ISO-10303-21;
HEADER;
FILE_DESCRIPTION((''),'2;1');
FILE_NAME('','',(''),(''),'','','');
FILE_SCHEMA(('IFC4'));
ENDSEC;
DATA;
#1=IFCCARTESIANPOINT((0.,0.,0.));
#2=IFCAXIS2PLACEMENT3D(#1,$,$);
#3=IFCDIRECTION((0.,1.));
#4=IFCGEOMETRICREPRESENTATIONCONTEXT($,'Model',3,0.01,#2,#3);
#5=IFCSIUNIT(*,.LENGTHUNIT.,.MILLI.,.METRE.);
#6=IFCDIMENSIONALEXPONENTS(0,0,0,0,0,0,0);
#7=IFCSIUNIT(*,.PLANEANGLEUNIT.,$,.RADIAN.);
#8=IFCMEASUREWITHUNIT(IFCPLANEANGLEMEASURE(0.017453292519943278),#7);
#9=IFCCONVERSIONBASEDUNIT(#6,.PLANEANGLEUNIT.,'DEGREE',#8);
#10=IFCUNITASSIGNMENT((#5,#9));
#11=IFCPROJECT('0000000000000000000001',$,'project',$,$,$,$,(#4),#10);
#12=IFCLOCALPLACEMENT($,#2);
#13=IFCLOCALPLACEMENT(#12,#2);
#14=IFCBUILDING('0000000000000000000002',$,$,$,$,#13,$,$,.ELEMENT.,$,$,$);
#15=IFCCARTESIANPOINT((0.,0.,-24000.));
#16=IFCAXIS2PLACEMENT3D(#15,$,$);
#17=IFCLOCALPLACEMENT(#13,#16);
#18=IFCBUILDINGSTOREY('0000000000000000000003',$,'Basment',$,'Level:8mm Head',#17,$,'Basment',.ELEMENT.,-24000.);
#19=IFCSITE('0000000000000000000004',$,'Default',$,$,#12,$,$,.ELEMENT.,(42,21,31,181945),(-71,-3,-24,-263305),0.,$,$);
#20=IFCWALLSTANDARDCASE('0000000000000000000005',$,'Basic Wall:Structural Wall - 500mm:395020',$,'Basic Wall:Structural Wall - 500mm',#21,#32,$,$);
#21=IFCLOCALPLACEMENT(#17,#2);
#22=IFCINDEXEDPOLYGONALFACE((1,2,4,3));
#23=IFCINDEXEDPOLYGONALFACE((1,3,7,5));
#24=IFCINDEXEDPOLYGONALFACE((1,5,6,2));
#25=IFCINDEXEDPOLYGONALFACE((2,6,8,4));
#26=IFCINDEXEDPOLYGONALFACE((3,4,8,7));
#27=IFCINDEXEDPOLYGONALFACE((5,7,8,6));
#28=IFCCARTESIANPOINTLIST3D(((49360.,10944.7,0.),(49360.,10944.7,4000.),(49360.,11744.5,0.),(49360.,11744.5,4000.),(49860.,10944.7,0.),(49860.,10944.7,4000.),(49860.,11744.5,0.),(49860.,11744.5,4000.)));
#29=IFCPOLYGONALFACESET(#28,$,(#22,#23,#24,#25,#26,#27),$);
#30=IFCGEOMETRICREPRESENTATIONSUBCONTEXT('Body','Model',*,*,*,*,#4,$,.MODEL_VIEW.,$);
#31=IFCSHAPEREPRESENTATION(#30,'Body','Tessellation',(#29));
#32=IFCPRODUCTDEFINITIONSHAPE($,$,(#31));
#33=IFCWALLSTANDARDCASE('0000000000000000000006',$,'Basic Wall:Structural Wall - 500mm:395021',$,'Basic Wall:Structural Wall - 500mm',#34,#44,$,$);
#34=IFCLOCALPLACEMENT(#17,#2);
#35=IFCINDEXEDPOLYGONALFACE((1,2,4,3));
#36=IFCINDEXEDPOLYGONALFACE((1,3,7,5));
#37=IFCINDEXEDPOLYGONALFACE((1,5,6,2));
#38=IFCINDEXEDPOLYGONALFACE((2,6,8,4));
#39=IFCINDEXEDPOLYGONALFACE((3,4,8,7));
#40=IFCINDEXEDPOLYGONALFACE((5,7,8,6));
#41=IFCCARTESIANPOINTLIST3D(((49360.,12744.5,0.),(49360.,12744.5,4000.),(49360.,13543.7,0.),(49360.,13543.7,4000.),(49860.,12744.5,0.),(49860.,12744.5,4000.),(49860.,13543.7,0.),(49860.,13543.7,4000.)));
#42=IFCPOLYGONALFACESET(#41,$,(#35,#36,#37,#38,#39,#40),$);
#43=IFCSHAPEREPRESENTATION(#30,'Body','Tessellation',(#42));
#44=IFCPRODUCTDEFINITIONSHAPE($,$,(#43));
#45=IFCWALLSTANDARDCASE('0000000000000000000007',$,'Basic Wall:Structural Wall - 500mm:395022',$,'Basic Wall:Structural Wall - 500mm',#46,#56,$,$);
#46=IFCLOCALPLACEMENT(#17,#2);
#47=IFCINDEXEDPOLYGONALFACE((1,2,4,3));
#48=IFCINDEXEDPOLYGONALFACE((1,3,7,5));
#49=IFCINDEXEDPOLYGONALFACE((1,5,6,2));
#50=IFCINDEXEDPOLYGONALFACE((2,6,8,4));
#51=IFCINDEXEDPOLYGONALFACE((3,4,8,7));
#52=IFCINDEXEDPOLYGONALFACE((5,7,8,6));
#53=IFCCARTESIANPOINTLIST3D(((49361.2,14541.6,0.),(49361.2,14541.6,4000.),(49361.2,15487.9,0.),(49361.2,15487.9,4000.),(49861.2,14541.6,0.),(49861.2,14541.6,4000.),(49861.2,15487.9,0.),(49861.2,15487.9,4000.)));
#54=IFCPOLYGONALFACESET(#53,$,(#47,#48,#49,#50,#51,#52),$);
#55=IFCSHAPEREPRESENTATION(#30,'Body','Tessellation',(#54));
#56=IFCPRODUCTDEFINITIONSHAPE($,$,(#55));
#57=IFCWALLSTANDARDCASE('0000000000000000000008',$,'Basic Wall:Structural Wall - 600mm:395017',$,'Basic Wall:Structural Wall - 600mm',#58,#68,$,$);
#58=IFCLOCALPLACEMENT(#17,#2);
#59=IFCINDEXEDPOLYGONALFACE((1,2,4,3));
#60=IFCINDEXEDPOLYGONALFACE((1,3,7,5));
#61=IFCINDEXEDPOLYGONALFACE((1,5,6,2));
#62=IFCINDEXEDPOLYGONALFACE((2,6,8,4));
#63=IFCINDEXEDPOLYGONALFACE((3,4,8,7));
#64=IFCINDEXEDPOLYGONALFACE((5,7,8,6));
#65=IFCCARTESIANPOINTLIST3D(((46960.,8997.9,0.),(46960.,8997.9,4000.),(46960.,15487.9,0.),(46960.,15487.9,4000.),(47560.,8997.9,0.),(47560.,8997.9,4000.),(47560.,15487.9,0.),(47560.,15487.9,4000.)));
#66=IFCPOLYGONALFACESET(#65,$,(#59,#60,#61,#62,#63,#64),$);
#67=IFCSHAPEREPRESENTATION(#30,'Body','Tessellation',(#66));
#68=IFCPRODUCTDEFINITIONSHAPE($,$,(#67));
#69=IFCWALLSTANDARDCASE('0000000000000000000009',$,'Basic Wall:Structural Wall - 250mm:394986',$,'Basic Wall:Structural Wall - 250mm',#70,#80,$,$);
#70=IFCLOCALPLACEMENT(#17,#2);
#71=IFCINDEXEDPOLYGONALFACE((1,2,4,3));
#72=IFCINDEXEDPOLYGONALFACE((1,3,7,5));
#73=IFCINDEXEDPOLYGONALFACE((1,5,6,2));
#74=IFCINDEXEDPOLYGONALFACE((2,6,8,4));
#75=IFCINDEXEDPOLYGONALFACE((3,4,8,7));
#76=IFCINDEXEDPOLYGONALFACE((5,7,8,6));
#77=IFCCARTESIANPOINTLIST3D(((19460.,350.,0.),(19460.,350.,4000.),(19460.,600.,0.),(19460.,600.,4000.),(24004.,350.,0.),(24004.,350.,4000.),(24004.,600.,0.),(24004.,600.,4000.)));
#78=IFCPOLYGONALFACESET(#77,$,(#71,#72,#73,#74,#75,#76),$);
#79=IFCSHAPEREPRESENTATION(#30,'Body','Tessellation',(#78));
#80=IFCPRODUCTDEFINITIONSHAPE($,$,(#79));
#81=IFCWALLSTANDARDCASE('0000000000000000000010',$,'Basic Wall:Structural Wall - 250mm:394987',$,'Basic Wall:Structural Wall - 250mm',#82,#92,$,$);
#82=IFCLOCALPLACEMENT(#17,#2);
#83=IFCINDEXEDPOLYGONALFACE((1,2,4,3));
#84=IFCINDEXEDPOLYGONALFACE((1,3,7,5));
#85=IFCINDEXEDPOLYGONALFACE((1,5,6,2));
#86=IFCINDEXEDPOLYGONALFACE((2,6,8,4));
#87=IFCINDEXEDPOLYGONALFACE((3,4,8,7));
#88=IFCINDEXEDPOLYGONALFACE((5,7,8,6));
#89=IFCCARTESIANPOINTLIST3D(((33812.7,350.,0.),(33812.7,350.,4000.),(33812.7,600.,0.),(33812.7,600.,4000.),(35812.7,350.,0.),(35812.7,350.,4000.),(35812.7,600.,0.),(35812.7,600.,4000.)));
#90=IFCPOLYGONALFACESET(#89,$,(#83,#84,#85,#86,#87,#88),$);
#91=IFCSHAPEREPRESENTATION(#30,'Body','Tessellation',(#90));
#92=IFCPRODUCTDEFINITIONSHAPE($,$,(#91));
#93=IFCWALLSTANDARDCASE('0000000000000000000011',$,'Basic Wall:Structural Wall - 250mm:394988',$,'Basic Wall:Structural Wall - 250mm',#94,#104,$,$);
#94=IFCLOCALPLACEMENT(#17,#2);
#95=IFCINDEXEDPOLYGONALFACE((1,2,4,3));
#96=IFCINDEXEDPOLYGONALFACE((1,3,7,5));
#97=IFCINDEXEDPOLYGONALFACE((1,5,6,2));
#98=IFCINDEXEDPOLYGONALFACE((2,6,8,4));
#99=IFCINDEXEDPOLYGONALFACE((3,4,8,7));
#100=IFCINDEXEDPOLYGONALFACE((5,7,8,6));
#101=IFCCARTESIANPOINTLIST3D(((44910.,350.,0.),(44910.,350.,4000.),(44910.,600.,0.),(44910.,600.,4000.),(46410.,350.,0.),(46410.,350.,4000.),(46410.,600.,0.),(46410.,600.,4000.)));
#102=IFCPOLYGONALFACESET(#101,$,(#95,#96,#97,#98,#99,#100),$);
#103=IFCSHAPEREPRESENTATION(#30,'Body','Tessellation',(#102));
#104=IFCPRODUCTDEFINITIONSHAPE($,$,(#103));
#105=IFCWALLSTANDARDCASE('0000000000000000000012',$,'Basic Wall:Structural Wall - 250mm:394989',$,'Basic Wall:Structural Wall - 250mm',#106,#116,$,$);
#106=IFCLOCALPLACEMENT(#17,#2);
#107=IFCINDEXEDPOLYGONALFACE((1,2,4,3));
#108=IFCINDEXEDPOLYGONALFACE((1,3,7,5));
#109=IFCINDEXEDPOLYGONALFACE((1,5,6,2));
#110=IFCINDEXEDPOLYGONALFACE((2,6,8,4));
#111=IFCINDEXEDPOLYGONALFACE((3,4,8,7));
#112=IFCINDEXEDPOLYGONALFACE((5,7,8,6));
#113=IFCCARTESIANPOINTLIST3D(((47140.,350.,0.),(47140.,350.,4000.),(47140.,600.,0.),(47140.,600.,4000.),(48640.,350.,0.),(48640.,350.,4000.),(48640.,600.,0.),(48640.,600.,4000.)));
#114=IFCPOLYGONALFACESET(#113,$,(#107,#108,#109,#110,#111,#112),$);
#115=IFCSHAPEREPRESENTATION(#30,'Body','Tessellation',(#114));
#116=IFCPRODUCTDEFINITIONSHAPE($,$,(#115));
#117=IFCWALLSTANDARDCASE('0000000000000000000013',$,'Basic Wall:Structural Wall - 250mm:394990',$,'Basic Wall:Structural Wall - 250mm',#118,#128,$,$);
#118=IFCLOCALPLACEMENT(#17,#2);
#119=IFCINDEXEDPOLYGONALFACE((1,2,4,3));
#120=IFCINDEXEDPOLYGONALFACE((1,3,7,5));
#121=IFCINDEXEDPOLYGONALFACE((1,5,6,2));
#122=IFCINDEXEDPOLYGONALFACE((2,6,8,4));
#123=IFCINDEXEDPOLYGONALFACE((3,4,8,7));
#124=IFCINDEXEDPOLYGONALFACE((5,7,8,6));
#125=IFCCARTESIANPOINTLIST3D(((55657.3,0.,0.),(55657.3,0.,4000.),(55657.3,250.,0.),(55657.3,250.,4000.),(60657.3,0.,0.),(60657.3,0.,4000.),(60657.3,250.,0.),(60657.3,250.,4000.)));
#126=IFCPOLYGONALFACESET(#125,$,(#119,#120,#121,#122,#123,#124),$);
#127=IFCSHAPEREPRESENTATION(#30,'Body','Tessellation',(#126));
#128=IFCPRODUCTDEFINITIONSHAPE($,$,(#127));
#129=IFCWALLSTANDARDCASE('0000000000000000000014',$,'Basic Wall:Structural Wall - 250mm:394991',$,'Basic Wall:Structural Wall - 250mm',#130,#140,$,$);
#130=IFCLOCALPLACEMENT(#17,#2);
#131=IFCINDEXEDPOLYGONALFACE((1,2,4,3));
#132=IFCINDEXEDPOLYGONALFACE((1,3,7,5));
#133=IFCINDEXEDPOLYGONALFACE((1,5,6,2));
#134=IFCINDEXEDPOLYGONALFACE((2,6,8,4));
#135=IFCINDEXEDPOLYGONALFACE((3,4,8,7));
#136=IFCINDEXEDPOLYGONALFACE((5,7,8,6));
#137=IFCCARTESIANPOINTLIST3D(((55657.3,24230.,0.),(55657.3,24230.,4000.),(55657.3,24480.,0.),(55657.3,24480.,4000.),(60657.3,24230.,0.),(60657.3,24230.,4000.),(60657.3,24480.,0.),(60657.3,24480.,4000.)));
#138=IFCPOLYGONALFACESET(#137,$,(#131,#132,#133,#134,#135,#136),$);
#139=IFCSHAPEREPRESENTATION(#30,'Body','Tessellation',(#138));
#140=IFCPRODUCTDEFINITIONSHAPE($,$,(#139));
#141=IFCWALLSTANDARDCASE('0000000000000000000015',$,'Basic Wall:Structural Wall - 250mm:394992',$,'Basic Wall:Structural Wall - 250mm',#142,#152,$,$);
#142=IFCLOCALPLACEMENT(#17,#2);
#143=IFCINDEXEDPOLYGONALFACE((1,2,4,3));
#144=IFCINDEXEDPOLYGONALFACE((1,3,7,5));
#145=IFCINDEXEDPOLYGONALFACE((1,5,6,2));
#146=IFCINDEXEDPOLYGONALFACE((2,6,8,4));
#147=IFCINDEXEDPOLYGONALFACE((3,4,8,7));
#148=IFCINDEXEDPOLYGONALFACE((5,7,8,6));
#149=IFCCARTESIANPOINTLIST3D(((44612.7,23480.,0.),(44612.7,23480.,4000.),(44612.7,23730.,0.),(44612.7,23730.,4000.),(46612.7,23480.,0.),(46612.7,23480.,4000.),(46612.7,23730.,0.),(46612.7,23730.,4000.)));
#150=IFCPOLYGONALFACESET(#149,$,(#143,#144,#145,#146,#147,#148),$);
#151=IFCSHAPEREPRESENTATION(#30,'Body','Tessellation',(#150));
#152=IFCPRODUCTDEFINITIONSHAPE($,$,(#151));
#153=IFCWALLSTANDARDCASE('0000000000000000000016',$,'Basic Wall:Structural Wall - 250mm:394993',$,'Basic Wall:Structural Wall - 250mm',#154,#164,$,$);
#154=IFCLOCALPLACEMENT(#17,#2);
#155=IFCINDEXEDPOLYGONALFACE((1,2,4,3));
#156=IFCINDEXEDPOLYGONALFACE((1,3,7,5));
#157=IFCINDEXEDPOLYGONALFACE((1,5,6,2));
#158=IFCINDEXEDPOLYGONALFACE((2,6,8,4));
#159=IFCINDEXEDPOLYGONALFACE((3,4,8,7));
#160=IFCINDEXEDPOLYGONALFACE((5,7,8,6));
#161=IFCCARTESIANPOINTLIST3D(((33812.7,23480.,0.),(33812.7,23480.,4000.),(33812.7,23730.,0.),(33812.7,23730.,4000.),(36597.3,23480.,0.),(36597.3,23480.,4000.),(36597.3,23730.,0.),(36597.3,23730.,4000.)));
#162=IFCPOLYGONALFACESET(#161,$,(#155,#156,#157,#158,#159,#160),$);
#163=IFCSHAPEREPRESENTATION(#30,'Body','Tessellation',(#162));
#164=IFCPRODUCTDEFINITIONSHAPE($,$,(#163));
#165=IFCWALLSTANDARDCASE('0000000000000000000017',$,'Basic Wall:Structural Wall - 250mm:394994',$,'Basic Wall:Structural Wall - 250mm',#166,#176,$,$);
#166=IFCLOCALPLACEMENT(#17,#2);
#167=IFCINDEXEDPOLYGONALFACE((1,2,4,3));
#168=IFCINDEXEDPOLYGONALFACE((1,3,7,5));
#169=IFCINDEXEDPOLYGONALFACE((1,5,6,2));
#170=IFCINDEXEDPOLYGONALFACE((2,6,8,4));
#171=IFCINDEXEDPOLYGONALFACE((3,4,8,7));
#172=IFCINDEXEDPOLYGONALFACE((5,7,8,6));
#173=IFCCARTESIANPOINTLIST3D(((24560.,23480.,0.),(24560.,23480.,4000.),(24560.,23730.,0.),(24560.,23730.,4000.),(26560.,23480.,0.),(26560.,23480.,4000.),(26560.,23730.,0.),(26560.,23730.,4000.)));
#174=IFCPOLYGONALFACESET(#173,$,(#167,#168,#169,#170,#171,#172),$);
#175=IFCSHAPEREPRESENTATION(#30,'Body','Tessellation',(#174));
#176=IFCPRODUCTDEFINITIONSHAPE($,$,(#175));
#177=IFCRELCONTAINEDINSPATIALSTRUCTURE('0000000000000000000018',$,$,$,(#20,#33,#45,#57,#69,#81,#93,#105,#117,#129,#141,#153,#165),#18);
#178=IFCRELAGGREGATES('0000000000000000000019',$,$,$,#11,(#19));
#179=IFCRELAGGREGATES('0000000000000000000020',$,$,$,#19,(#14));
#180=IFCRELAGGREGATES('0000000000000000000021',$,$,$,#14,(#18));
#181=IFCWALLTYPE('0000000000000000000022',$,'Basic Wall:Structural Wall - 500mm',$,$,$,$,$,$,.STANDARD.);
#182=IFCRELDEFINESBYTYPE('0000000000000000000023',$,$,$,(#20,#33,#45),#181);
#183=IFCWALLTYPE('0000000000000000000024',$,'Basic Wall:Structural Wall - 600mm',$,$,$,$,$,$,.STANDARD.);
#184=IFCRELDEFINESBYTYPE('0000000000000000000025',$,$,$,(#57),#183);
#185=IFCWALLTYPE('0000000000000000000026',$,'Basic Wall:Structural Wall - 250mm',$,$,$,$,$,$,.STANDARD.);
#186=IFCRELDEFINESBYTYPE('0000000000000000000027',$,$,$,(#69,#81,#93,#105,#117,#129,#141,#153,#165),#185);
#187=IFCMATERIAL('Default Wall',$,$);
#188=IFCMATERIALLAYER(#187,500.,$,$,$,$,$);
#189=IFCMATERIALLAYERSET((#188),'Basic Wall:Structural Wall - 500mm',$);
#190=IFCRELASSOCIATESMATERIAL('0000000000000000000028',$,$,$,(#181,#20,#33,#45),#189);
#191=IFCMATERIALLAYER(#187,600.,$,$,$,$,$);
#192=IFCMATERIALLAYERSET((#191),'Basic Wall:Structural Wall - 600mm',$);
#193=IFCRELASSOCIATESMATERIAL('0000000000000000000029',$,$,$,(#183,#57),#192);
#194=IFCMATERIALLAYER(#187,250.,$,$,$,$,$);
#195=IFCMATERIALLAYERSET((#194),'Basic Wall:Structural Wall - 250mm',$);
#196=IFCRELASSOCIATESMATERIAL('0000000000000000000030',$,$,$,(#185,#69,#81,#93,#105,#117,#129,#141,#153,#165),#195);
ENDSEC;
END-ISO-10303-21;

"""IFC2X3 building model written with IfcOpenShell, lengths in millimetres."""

from ifc_helpers import new_model, entity, si_unit, converted_unit, direction, frame, frame_2d, origin, place, context, subcontext, project, spatial, rectangle, extrude, material, layer, layer_set, layer_usage, type_object, element, save


model = new_model("IFC2X3")

# Units and contexts
model_context = context("Model", 3, precision=0.01, world=origin(), true_north=direction((0.0, 1.0)))
body_context = subcontext(model_context, "Body", "Model", "MODEL_VIEW")
ifc_project = project(units=[si_unit("LENGTHUNIT", "METRE", prefix="MILLI"), converted_unit("PLANEANGLEUNIT", "DEGREE", entity("IfcPlaneAngleMeasure", 0.017453292519943278), si_unit("PLANEANGLEUNIT", "RADIAN"), dimensions=[0, 0, 0, 0, 0, 0, 0])], contexts=[model_context])

# Site, building, storey
site_placement = place(None, origin())
site = spatial("IfcSite", under=ifc_project, at=site_placement, Name="Default", CompositionType="ELEMENT", RefLatitude=(42, 21, 31, 181945), RefLongitude=(-71, -3, -24, -263305), RefElevation=0.0)
building_placement = place(site_placement, origin())
building = spatial("IfcBuilding", under=site, at=building_placement, CompositionType="ELEMENT")
storey_placement = place(building_placement, frame((0.0, 0.0, -24000.0)))
storey = spatial("IfcBuildingStorey", under=building, at=storey_placement, Name="Basment", ObjectType="Level:8mm Head", LongName="Basment", CompositionType="ELEMENT", Elevation=-24000.0)

# Walls
ifc_material_1 = material(Name="Default Wall")
ifc_layer_1 = layer(ifc_material_1, 500.0)
ifc_layer_set_1 = layer_set([ifc_layer_1], Name="Basic Wall:Structural Wall - 500mm")
wall_type_1 = type_object("IfcWallType", Name="Basic Wall:Structural Wall - 500mm", PredefinedType="STANDARD", material=ifc_layer_set_1)
ifc_layer_usage_1 = layer_usage(ifc_layer_set_1, "AXIS2", "NEGATIVE", 250.0)
wall_1_placement = place(storey_placement, frame((49610.0, 10944.7, 0.0), z_axis=(0.0, 0.0, 1.0), x_axis=(0.0, 1.0, 0.0)))
element("IfcWallStandardCase", 1, at=wall_1_placement, inside=storey, type_object=wall_type_1, material=ifc_layer_usage_1, Name="Basic Wall:Structural Wall - 500mm:395020", ObjectType="Basic Wall:Structural Wall - 500mm", context=body_context, shape_type="SweptSolid", body=[
    extrude(rectangle(XDim=799.8, YDim=500.0, at=frame_2d((399.9, 0.0), x_axis=(-1.0, 0.0))), origin(), (0.0, 0.0, 1.0), 4000.0),
])
ifc_layer_usage_2 = layer_usage(ifc_layer_set_1, "AXIS2", "NEGATIVE", 250.0)
wall_2_placement = place(storey_placement, frame((49610.0, 12744.5, 0.0), z_axis=(0.0, 0.0, 1.0), x_axis=(0.0, 1.0, 0.0)))
element("IfcWallStandardCase", 2, at=wall_2_placement, inside=storey, type_object=wall_type_1, material=ifc_layer_usage_2, Name="Basic Wall:Structural Wall - 500mm:395021", ObjectType="Basic Wall:Structural Wall - 500mm", context=body_context, shape_type="SweptSolid", body=[
    extrude(rectangle(XDim=799.2, YDim=500.0, at=frame_2d((399.6, 0.0), x_axis=(-1.0, 0.0))), origin(), (0.0, 0.0, 1.0), 4000.0),
])
ifc_layer_usage_3 = layer_usage(ifc_layer_set_1, "AXIS2", "NEGATIVE", 250.0)
wall_3_placement = place(storey_placement, frame((49611.2, 14541.6, 0.0), z_axis=(0.0, 0.0, 1.0), x_axis=(0.0, 1.0, 0.0)))
element("IfcWallStandardCase", 3, at=wall_3_placement, inside=storey, type_object=wall_type_1, material=ifc_layer_usage_3, Name="Basic Wall:Structural Wall - 500mm:395022", ObjectType="Basic Wall:Structural Wall - 500mm", context=body_context, shape_type="SweptSolid", body=[
    extrude(rectangle(XDim=946.3, YDim=500.0, at=frame_2d((473.2, 0.0), x_axis=(-1.0, 0.0))), origin(), (0.0, 0.0, 1.0), 4000.0),
])
ifc_layer_2 = layer(ifc_material_1, 600.0)
ifc_layer_set_2 = layer_set([ifc_layer_2], Name="Basic Wall:Structural Wall - 600mm")
ifc_layer_usage_4 = layer_usage(ifc_layer_set_2, "AXIS2", "NEGATIVE", 300.0)
wall_type_2 = type_object("IfcWallType", Name="Basic Wall:Structural Wall - 600mm", PredefinedType="STANDARD", material=ifc_layer_set_2)
wall_4_placement = place(storey_placement, frame((47260.0, 15487.9, 0.0), z_axis=(0.0, 0.0, 1.0), x_axis=(0.0, -1.0, 0.0)))
element("IfcWallStandardCase", 4, at=wall_4_placement, inside=storey, type_object=wall_type_2, material=ifc_layer_usage_4, Name="Basic Wall:Structural Wall - 600mm:395017", ObjectType="Basic Wall:Structural Wall - 600mm", context=body_context, shape_type="SweptSolid", body=[
    extrude(rectangle(XDim=6490.0, YDim=600.0, at=frame_2d((3245.0, 0.0), x_axis=(-1.0, 0.0))), origin(), (0.0, 0.0, 1.0), 4000.0),
])
ifc_layer_3 = layer(ifc_material_1, 250.0)
ifc_layer_set_3 = layer_set([ifc_layer_3], Name="Basic Wall:Structural Wall - 250mm")
ifc_layer_usage_5 = layer_usage(ifc_layer_set_3, "AXIS2", "NEGATIVE", 125.0)
wall_type_3 = type_object("IfcWallType", Name="Basic Wall:Structural Wall - 250mm", PredefinedType="STANDARD", material=ifc_layer_set_3)
wall_5_placement = place(storey_placement, frame((24004.0, 475.0, 0.0), z_axis=(0.0, 0.0, 1.0), x_axis=(-1.0, 0.0, 0.0)))
element("IfcWallStandardCase", 5, at=wall_5_placement, inside=storey, type_object=wall_type_3, material=ifc_layer_usage_5, Name="Basic Wall:Structural Wall - 250mm:394986", ObjectType="Basic Wall:Structural Wall - 250mm", context=body_context, shape_type="SweptSolid", body=[
    extrude(rectangle(XDim=4544.0, YDim=250.0, at=frame_2d((2272.0, 0.0), x_axis=(-1.0, 0.0))), origin(), (0.0, 0.0, 1.0), 4000.0),
])
ifc_layer_usage_6 = layer_usage(ifc_layer_set_3, "AXIS2", "NEGATIVE", 125.0)
wall_6_placement = place(storey_placement, frame((35812.7, 475.0, 0.0), z_axis=(0.0, 0.0, 1.0), x_axis=(-1.0, 0.0, 0.0)))
element("IfcWallStandardCase", 6, at=wall_6_placement, inside=storey, type_object=wall_type_3, material=ifc_layer_usage_6, Name="Basic Wall:Structural Wall - 250mm:394987", ObjectType="Basic Wall:Structural Wall - 250mm", context=body_context, shape_type="SweptSolid", body=[
    extrude(rectangle(XDim=2000.0, YDim=250.0, at=frame_2d((1000.0, 0.0), x_axis=(-1.0, 0.0))), origin(), (0.0, 0.0, 1.0), 4000.0),
])
ifc_layer_usage_7 = layer_usage(ifc_layer_set_3, "AXIS2", "NEGATIVE", 125.0)
wall_7_placement = place(storey_placement, frame((46410.0, 475.0, 0.0), z_axis=(0.0, 0.0, 1.0), x_axis=(-1.0, 0.0, 0.0)))
element("IfcWallStandardCase", 7, at=wall_7_placement, inside=storey, type_object=wall_type_3, material=ifc_layer_usage_7, Name="Basic Wall:Structural Wall - 250mm:394988", ObjectType="Basic Wall:Structural Wall - 250mm", context=body_context, shape_type="SweptSolid", body=[
    extrude(rectangle(XDim=1500.0, YDim=250.0, at=frame_2d((750.0, 0.0), x_axis=(-1.0, 0.0))), origin(), (0.0, 0.0, 1.0), 4000.0),
])
ifc_layer_usage_8 = layer_usage(ifc_layer_set_3, "AXIS2", "NEGATIVE", 125.0)
wall_8_placement = place(storey_placement, frame((48640.0, 475.0, 0.0), z_axis=(0.0, 0.0, 1.0), x_axis=(-1.0, 0.0, 0.0)))
element("IfcWallStandardCase", 8, at=wall_8_placement, inside=storey, type_object=wall_type_3, material=ifc_layer_usage_8, Name="Basic Wall:Structural Wall - 250mm:394989", ObjectType="Basic Wall:Structural Wall - 250mm", context=body_context, shape_type="SweptSolid", body=[
    extrude(rectangle(XDim=1500.0, YDim=250.0, at=frame_2d((750.0, 0.0), x_axis=(-1.0, 0.0))), origin(), (0.0, 0.0, 1.0), 4000.0),
])
ifc_layer_usage_9 = layer_usage(ifc_layer_set_3, "AXIS2", "NEGATIVE", 125.0)
wall_9_placement = place(storey_placement, frame((60657.3, 125.0, 0.0), z_axis=(0.0, 0.0, 1.0), x_axis=(-1.0, 0.0, 0.0)))
element("IfcWallStandardCase", 9, at=wall_9_placement, inside=storey, type_object=wall_type_3, material=ifc_layer_usage_9, Name="Basic Wall:Structural Wall - 250mm:394990", ObjectType="Basic Wall:Structural Wall - 250mm", context=body_context, shape_type="SweptSolid", body=[
    extrude(rectangle(XDim=5000.0, YDim=250.0, at=frame_2d((2500.0, 0.0), x_axis=(-1.0, 0.0))), origin(), (0.0, 0.0, 1.0), 4000.0),
])
ifc_layer_usage_10 = layer_usage(ifc_layer_set_3, "AXIS2", "NEGATIVE", 125.0)
wall_10_placement = place(storey_placement, frame((55657.3, 24355.0, 0.0)))
element("IfcWallStandardCase", 10, at=wall_10_placement, inside=storey, type_object=wall_type_3, material=ifc_layer_usage_10, Name="Basic Wall:Structural Wall - 250mm:394991", ObjectType="Basic Wall:Structural Wall - 250mm", context=body_context, shape_type="SweptSolid", body=[
    extrude(rectangle(XDim=5000.0, YDim=250.0, at=frame_2d((2500.0, 0.0), x_axis=(-1.0, 0.0))), origin(), (0.0, 0.0, 1.0), 4000.0),
])
ifc_layer_usage_11 = layer_usage(ifc_layer_set_3, "AXIS2", "NEGATIVE", 125.0)
wall_11_placement = place(storey_placement, frame((44612.7, 23605.0, 0.0)))
element("IfcWallStandardCase", 11, at=wall_11_placement, inside=storey, type_object=wall_type_3, material=ifc_layer_usage_11, Name="Basic Wall:Structural Wall - 250mm:394992", ObjectType="Basic Wall:Structural Wall - 250mm", context=body_context, shape_type="SweptSolid", body=[
    extrude(rectangle(XDim=2000.0, YDim=250.0, at=frame_2d((1000.0, 0.0), x_axis=(-1.0, 0.0))), origin(), (0.0, 0.0, 1.0), 4000.0),
])
ifc_layer_usage_12 = layer_usage(ifc_layer_set_3, "AXIS2", "NEGATIVE", 125.0)
wall_12_placement = place(storey_placement, frame((33812.7, 23605.0, 0.0)))
element("IfcWallStandardCase", 12, at=wall_12_placement, inside=storey, type_object=wall_type_3, material=ifc_layer_usage_12, Name="Basic Wall:Structural Wall - 250mm:394993", ObjectType="Basic Wall:Structural Wall - 250mm", context=body_context, shape_type="SweptSolid", body=[
    extrude(rectangle(XDim=2784.7, YDim=250.0, at=frame_2d((1392.3, 0.0), x_axis=(-1.0, 0.0))), origin(), (0.0, 0.0, 1.0), 4000.0),
])
ifc_layer_usage_13 = layer_usage(ifc_layer_set_3, "AXIS2", "NEGATIVE", 125.0)
wall_13_placement = place(storey_placement, frame((24560.0, 23605.0, 0.0)))
element("IfcWallStandardCase", 13, at=wall_13_placement, inside=storey, type_object=wall_type_3, material=ifc_layer_usage_13, Name="Basic Wall:Structural Wall - 250mm:394994", ObjectType="Basic Wall:Structural Wall - 250mm", context=body_context, shape_type="SweptSolid", body=[
    extrude(rectangle(XDim=2000.0, YDim=250.0, at=frame_2d((1000.0, 0.0), x_axis=(-1.0, 0.0))), origin(), (0.0, 0.0, 1.0), 4000.0),
])

save(model, "model.ifc")
